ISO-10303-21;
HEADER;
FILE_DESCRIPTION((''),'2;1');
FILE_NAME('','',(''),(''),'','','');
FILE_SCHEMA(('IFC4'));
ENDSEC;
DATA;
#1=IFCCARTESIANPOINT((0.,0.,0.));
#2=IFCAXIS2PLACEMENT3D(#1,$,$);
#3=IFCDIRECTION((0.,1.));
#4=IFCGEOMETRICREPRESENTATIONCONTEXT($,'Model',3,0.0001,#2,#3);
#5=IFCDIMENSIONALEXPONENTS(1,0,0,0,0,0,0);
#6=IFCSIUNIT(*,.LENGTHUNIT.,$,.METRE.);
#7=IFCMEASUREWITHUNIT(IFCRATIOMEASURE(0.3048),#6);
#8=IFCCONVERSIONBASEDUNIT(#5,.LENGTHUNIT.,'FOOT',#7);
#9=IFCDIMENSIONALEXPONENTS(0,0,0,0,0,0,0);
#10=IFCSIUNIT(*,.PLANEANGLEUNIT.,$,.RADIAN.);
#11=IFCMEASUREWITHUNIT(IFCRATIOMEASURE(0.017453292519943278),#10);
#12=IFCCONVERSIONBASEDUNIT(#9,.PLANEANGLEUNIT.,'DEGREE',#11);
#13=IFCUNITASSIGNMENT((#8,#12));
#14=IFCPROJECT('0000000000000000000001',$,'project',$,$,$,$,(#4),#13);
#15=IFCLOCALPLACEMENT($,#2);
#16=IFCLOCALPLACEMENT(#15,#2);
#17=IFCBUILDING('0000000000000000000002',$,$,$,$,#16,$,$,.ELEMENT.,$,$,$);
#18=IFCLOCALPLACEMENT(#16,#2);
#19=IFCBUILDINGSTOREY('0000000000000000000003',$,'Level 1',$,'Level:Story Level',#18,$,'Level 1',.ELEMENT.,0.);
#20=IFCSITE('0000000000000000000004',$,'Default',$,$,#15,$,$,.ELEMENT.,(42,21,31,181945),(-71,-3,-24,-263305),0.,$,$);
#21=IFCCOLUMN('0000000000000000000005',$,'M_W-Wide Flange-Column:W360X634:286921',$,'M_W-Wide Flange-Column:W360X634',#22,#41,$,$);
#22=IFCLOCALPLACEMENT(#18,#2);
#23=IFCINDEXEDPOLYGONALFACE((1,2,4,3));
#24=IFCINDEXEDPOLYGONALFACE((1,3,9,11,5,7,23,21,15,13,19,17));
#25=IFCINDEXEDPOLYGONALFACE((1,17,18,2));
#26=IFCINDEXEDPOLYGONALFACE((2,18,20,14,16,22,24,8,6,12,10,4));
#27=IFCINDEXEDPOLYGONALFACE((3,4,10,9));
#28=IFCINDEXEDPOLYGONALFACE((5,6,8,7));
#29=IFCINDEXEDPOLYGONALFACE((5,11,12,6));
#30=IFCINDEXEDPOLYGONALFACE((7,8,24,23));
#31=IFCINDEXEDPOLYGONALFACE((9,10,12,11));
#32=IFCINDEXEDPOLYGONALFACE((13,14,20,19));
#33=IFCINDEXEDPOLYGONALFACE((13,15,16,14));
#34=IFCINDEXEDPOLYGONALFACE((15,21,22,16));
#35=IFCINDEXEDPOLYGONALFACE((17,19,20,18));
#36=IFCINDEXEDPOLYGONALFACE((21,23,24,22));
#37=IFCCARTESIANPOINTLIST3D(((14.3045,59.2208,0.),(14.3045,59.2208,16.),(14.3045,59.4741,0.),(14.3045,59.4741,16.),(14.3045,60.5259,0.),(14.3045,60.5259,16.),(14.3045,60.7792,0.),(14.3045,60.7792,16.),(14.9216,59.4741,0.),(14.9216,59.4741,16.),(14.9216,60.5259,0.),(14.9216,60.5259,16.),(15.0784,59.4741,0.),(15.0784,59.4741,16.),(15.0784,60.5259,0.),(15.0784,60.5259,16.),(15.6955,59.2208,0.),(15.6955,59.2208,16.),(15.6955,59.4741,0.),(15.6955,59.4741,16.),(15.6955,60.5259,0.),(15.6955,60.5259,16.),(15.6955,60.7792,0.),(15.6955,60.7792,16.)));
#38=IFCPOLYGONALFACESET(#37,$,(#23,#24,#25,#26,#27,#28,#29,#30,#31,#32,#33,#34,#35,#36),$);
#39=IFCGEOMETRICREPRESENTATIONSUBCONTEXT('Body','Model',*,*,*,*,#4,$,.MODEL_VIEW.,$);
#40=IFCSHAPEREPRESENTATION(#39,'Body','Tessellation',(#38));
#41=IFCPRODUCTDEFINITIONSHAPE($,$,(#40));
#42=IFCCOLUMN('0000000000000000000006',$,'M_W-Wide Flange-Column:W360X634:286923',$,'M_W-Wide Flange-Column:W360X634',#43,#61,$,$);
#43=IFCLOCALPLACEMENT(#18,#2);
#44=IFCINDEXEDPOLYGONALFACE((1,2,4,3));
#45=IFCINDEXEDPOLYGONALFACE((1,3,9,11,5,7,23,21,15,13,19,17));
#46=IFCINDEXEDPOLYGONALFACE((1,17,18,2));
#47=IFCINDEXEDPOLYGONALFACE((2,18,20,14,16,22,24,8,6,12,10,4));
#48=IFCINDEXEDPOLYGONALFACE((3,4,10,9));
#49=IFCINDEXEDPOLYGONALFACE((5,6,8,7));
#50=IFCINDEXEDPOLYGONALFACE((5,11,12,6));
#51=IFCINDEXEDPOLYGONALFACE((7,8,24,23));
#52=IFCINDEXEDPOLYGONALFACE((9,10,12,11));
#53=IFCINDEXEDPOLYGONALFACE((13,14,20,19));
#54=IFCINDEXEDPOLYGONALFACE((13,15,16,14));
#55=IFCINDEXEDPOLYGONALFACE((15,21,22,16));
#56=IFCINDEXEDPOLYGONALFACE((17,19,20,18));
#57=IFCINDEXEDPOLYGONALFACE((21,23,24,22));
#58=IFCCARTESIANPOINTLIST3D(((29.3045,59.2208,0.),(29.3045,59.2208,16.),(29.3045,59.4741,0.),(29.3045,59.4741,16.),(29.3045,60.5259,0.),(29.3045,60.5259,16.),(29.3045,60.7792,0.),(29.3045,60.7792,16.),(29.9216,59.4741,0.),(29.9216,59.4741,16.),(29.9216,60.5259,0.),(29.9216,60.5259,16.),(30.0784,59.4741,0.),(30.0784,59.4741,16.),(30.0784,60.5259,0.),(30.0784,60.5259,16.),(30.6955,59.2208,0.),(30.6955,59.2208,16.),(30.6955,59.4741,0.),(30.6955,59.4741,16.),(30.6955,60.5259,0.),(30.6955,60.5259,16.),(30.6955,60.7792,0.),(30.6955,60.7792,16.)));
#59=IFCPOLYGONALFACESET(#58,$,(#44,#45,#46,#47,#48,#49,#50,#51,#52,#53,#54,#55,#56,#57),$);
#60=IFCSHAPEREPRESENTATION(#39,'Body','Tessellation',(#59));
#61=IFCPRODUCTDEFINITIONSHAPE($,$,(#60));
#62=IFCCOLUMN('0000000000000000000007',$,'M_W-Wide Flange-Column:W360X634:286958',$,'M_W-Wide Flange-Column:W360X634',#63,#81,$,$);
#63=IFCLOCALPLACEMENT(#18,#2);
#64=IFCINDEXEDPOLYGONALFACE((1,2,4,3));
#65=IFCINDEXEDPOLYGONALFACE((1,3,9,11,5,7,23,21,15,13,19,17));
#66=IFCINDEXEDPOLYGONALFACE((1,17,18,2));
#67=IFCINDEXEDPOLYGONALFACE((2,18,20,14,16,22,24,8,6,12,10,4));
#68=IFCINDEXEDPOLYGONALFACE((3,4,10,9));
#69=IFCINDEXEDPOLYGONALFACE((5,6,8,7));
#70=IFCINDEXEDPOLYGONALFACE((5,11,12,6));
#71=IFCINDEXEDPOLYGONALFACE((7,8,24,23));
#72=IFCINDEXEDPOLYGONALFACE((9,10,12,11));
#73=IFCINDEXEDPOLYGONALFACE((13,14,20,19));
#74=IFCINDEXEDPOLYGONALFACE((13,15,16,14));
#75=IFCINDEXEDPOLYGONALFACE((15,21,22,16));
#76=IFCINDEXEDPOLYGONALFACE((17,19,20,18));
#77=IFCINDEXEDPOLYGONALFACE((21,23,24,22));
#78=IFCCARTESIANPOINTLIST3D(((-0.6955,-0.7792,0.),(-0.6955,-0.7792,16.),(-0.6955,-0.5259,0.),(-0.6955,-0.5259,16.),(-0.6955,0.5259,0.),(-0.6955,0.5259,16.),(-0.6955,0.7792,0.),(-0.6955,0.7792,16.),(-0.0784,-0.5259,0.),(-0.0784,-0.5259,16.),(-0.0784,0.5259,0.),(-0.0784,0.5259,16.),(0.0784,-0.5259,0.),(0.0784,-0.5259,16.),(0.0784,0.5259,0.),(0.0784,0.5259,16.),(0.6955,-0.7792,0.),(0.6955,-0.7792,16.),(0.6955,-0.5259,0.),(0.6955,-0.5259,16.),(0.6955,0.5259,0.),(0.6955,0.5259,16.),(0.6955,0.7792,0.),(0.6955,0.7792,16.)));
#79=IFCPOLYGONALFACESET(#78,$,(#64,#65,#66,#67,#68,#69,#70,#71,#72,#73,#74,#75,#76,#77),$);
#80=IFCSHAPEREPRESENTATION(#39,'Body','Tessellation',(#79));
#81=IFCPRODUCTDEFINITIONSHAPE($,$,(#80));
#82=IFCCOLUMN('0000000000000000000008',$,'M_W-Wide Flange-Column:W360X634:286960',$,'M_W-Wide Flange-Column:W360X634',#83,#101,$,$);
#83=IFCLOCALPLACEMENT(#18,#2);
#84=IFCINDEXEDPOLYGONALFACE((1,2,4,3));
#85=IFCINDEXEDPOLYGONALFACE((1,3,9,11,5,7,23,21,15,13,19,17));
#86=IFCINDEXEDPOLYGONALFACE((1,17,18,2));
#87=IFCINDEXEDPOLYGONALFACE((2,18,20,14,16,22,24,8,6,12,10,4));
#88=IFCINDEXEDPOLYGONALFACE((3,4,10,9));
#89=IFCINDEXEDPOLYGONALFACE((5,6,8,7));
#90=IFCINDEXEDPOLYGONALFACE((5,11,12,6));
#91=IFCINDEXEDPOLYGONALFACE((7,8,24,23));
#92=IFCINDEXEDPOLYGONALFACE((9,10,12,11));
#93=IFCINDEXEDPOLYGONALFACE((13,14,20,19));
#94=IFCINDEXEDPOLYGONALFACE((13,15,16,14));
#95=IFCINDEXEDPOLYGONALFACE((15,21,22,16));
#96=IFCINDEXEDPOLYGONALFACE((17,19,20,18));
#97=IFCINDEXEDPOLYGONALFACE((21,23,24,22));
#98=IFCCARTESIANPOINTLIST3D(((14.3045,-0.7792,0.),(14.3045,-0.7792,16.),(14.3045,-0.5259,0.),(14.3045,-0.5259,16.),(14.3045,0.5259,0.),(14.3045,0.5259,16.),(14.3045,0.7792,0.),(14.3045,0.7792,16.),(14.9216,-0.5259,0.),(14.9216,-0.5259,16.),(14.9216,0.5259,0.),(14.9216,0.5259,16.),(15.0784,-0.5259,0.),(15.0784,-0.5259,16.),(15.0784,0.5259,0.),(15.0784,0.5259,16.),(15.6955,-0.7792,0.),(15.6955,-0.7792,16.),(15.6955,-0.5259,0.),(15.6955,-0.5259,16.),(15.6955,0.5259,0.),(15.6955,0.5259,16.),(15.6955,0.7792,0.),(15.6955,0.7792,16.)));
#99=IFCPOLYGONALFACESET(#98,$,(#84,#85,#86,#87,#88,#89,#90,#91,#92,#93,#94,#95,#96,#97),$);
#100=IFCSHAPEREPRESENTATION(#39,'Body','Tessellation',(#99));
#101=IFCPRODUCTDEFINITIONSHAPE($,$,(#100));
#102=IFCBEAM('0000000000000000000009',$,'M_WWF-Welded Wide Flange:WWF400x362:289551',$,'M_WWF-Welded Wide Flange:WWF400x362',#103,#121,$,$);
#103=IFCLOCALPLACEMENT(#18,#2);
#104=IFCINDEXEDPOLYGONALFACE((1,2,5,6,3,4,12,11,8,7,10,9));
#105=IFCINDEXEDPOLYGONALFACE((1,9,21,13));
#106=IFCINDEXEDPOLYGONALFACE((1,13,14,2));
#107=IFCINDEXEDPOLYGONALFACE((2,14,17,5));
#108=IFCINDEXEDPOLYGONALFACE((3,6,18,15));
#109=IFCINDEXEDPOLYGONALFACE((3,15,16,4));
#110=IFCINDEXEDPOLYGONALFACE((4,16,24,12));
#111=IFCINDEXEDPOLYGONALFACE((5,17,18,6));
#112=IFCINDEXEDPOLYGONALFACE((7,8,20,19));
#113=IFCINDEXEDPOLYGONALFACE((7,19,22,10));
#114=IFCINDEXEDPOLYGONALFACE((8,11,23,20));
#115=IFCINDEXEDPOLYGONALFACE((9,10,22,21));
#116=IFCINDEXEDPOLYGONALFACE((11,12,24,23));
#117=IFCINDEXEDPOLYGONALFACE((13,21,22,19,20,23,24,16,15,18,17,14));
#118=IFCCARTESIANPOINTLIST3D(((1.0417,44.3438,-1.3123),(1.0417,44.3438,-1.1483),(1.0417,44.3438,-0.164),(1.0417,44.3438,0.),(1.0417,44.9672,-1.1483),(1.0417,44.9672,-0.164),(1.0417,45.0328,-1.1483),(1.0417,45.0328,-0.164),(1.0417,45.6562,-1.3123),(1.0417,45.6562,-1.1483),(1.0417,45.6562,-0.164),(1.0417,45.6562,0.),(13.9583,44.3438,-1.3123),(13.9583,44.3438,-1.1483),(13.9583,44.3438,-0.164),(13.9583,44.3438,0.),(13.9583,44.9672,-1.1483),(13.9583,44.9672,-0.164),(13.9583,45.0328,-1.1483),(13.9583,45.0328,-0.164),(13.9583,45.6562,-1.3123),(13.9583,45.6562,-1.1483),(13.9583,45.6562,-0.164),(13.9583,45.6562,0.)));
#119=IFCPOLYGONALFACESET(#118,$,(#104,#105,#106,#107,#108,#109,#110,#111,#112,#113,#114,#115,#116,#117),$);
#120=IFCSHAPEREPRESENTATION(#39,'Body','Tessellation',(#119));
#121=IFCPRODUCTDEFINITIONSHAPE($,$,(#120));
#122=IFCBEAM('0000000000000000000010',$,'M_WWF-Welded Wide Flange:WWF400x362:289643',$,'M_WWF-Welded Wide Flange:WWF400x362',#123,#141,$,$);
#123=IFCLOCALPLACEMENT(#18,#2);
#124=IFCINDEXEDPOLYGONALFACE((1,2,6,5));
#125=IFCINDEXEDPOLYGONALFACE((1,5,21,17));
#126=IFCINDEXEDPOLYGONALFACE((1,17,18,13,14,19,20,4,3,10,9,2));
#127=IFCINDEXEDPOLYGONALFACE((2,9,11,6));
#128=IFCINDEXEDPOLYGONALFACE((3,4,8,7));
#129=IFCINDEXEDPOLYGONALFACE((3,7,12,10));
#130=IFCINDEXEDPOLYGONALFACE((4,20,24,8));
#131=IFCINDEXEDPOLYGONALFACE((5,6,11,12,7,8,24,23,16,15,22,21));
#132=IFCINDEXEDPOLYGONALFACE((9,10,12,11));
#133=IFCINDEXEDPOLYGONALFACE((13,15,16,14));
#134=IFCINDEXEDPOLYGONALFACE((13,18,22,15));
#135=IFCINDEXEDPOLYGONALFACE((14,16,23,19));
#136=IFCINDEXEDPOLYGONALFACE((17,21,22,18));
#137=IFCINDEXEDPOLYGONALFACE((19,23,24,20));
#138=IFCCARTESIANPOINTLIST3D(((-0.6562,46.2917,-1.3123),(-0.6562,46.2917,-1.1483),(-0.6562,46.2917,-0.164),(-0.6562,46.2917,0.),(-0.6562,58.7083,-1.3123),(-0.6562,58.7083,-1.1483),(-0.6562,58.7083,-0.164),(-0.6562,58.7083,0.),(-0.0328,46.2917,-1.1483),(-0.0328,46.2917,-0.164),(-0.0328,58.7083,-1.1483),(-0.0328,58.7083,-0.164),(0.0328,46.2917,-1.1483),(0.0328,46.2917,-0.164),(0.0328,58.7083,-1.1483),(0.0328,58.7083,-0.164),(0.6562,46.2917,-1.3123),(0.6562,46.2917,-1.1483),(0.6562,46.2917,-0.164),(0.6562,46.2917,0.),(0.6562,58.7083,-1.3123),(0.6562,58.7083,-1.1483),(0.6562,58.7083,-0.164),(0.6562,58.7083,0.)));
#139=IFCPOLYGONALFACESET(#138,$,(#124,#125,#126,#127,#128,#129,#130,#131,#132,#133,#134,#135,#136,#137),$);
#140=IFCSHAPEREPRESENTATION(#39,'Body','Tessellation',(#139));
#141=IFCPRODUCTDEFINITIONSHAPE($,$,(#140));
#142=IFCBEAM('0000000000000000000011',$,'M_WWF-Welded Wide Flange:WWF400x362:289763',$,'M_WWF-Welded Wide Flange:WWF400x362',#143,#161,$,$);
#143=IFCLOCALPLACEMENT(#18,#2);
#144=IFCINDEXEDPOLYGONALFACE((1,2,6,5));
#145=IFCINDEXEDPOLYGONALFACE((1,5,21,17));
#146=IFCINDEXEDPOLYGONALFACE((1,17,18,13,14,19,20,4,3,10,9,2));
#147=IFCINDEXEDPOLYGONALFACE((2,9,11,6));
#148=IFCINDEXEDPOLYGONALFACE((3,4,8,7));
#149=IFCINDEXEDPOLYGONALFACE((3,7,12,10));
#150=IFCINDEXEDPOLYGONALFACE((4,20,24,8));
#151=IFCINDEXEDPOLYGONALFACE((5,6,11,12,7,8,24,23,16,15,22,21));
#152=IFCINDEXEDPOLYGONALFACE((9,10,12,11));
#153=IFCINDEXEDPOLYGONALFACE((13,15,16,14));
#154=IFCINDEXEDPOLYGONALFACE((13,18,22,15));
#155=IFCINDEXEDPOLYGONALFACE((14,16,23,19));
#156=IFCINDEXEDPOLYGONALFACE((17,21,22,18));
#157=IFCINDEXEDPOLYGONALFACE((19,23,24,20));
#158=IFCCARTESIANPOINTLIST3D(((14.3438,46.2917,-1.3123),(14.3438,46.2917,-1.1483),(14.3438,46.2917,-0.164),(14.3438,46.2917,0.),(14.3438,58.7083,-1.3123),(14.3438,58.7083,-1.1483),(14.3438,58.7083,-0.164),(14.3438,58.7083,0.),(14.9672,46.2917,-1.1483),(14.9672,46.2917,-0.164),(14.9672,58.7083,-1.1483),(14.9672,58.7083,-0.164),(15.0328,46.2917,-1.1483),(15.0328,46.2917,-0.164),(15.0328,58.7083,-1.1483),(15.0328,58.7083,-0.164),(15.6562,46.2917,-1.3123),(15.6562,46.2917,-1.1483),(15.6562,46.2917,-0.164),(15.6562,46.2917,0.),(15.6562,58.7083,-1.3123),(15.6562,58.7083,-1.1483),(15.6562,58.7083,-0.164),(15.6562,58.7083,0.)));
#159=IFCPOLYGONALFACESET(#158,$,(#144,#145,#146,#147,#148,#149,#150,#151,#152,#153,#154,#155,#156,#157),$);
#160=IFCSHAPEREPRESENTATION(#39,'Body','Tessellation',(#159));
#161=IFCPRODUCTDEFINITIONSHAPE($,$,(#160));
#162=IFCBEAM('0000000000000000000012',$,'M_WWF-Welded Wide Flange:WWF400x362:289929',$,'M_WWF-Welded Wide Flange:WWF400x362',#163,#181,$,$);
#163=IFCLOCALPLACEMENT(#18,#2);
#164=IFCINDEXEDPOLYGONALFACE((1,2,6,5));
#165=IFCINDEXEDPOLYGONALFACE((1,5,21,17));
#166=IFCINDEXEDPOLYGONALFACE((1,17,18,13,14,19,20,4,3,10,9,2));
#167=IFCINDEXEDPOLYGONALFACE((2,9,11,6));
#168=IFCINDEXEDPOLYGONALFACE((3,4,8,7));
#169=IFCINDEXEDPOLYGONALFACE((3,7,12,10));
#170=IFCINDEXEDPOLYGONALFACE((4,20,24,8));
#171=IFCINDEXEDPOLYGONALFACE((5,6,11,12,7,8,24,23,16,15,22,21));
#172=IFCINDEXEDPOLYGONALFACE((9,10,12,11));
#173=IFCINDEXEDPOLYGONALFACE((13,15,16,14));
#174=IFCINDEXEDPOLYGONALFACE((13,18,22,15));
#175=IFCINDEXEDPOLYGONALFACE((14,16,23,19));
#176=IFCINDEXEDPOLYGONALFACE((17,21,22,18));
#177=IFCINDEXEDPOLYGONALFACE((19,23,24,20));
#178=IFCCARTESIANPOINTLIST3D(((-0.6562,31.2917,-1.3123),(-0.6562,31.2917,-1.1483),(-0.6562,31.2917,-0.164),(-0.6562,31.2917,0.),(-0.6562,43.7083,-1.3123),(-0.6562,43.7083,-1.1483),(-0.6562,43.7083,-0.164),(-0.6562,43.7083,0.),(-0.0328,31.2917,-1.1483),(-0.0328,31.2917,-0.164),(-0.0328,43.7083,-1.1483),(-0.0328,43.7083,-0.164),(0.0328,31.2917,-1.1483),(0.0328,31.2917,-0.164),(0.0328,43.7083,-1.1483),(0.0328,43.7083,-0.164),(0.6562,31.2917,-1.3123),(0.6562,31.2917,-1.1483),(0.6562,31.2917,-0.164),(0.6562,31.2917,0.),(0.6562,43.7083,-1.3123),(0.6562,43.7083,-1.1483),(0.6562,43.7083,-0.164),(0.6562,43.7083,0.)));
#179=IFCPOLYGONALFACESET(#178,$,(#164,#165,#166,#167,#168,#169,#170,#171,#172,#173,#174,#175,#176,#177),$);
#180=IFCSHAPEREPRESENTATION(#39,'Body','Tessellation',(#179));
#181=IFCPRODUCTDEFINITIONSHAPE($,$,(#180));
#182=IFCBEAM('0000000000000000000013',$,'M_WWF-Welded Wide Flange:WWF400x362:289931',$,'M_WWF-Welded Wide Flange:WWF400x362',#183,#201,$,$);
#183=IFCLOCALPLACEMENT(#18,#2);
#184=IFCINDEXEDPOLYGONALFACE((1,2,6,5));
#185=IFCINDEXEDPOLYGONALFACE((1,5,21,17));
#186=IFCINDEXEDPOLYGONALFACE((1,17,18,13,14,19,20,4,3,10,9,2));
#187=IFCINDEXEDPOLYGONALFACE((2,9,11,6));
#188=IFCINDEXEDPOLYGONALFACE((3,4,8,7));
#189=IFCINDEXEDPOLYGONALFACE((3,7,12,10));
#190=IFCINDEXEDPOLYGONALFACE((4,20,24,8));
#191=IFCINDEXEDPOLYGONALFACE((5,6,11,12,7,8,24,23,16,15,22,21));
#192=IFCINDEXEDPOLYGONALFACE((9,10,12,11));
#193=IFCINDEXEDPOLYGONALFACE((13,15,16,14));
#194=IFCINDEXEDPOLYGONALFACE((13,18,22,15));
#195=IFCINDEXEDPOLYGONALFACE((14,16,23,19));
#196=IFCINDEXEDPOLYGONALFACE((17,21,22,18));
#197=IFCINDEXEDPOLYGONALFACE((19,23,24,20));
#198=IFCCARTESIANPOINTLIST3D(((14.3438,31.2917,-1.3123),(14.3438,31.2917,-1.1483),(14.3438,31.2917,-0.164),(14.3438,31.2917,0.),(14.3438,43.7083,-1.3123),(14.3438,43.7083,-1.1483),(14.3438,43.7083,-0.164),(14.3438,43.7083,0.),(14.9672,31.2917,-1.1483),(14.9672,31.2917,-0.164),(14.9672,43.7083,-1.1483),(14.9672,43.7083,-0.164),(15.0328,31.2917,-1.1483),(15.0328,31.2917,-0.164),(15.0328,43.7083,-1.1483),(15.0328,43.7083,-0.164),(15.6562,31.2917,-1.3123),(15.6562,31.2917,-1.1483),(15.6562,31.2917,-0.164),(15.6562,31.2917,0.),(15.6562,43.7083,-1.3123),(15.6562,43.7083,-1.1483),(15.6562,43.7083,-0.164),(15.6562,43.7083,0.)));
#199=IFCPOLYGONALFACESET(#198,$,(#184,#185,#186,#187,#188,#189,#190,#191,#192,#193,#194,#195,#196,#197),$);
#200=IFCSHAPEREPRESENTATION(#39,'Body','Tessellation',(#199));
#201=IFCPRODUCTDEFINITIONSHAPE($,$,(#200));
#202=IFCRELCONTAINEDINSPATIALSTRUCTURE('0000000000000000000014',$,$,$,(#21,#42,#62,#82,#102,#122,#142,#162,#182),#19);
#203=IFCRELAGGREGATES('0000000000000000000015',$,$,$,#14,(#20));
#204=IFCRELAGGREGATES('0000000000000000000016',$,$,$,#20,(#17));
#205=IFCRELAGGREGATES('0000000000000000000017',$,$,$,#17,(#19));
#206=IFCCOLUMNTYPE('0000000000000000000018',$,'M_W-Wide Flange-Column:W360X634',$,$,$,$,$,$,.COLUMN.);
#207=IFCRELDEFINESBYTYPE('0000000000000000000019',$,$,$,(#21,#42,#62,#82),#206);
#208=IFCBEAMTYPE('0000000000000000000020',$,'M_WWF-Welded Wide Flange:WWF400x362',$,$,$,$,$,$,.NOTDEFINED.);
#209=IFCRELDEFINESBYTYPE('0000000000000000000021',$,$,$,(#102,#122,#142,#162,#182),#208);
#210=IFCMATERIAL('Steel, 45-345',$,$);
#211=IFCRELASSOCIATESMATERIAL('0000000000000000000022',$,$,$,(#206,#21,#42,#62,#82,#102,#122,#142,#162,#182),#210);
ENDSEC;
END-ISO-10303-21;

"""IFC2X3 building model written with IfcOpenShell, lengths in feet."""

from ifc_helpers import new_model, entity, si_unit, converted_unit, direction, frame, frame_2d, origin, place, context, subcontext, project, spatial, polyline, i_section, outline, extrude, source, transform, mapped, material, type_object, type_shapes, element, save


model = new_model("IFC2X3")

# Units and contexts
model_context = context("Model", 3, precision=0.0001, world=origin(), true_north=direction((0.0, 1.0)))
body_context = subcontext(model_context, "Body", "Model", "MODEL_VIEW")
ifc_project = project(units=[converted_unit("LENGTHUNIT", "FOOT", entity("IfcRatioMeasure", 0.3048), si_unit("LENGTHUNIT", "METRE"), dimensions=[1, 0, 0, 0, 0, 0, 0]), converted_unit("PLANEANGLEUNIT", "DEGREE", entity("IfcRatioMeasure", 0.017453292519943278), si_unit("PLANEANGLEUNIT", "RADIAN"), dimensions=[0, 0, 0, 0, 0, 0, 0])], contexts=[model_context])

# Site, building, storey
site_placement = place(None, origin())
site = spatial("IfcSite", under=ifc_project, at=site_placement, Name="Default", CompositionType="ELEMENT", RefLatitude=(42, 21, 31, 181945), RefLongitude=(-71, -3, -24, -263305), RefElevation=0.0)
building_placement = place(site_placement, origin())
building = spatial("IfcBuilding", under=site, at=building_placement, CompositionType="ELEMENT")
storey_placement = place(building_placement, origin())
storey = spatial("IfcBuildingStorey", under=building, at=storey_placement, Name="Level 1", ObjectType="Level:Story Level", LongName="Level 1", CompositionType="ELEMENT", Elevation=0.0)

# Columns
ifc_material = material(Name="Steel, 45-345")
column_type = type_object("IfcColumnType", Name="M_W-Wide Flange-Column:W360X634", PredefinedType="COLUMN", material=ifc_material)
shared_shape = source(origin(), body_context, "Body", "SweptSolid", [
    extrude(outline(polyline([(0.5259, -0.6955), (0.7792, -0.6955), (0.7792, 0.6955), (0.5259, 0.6955), (0.5259, 0.0784), (-0.5259, 0.0784), (-0.5259, 0.6955), (-0.7792, 0.6955), (-0.7792, -0.6955), (-0.5259, -0.6955), (-0.5259, -0.0784), (0.5259, -0.0784), (0.5259, -0.6955)])), frame((0.0, 0.0, 0.0), z_axis=(0.0, 0.0, 1.0), x_axis=(0.0, -1.0, 0.0)), (0.0, 0.0, 1.0), 16.0),
])
type_shapes(column_type, [shared_shape])
for number, where, name in (
    (1, (15.0, 60.0, 0.0), "M_W-Wide Flange-Column:W360X634:286921"),
    (2, (30.0, 60.0, 0.0), "M_W-Wide Flange-Column:W360X634:286923"),
    (3, (0.0, 0.0, 0.0), "M_W-Wide Flange-Column:W360X634:286958"),
    (4, (15.0, 0.0, 0.0), "M_W-Wide Flange-Column:W360X634:286960"),
):
    element("IfcColumn", number, at=place(storey_placement, frame(where)), inside=storey, type_object=column_type, material=ifc_material, Name=name, ObjectType="M_W-Wide Flange-Column:W360X634", context=body_context, shape_type="MappedRepresentation", body=[
        mapped(shared_shape, transform((0.0, 0.0, 0.0), scale=1.0)),
    ])

# Beams
beam_type = type_object("IfcBeamType", Name="M_WWF-Welded Wide Flange:WWF400x362", PredefinedType="NOTDEFINED")
beam_1_placement = place(storey_placement, frame((0.0, 45.0, 0.0)))
element("IfcBeam", 5, at=beam_1_placement, inside=storey, type_object=beam_type, material=ifc_material, Name="M_WWF-Welded Wide Flange:WWF400x362:289551", ObjectType="M_WWF-Welded Wide Flange:WWF400x362", context=body_context, shape_type="SweptSolid", body=[
    extrude(i_section(OverallWidth=1.3123, OverallDepth=1.3123, WebThickness=0.0656, FlangeThickness=0.164, at=frame_2d((0.0, 0.0), x_axis=(0.0, 1.0))), frame((1.0417, 0.0, -0.6562), z_axis=(1.0, 0.0, 0.0), x_axis=(0.0, 0.0, -1.0)), (0.0, 0.0, 1.0), 12.9167),
])
beam_2_placement = place(storey_placement, frame((0.0, 45.0, 0.0), z_axis=(0.0, 0.0, 1.0), x_axis=(0.0, 1.0, 0.0)))
element("IfcBeam", 6, at=beam_2_placement, inside=storey, type_object=beam_type, material=ifc_material, Name="M_WWF-Welded Wide Flange:WWF400x362:289643", ObjectType="M_WWF-Welded Wide Flange:WWF400x362", context=body_context, shape_type="SweptSolid", body=[
    extrude(i_section(OverallWidth=1.3123, OverallDepth=1.3123, WebThickness=0.0656, FlangeThickness=0.164, at=frame_2d((0.0, 0.0), x_axis=(0.0, 1.0))), frame((1.2917, 0.0, -0.6562), z_axis=(1.0, 0.0, 0.0), x_axis=(0.0, 0.0, -1.0)), (0.0, 0.0, 1.0), 12.4167),
])
beam_3_placement = place(storey_placement, frame((15.0, 45.0, 0.0), z_axis=(0.0, 0.0, 1.0), x_axis=(0.0, 1.0, 0.0)))
element("IfcBeam", 7, at=beam_3_placement, inside=storey, type_object=beam_type, material=ifc_material, Name="M_WWF-Welded Wide Flange:WWF400x362:289763", ObjectType="M_WWF-Welded Wide Flange:WWF400x362", context=body_context, shape_type="SweptSolid", body=[
    extrude(i_section(OverallWidth=1.3123, OverallDepth=1.3123, WebThickness=0.0656, FlangeThickness=0.164, at=frame_2d((0.0, 0.0), x_axis=(0.0, 1.0))), frame((1.2917, 0.0, -0.6562), z_axis=(1.0, 0.0, 0.0), x_axis=(0.0, 0.0, -1.0)), (0.0, 0.0, 1.0), 12.4167),
])
beam_4_placement = place(storey_placement, frame((0.0, 30.0, 0.0), z_axis=(0.0, 0.0, 1.0), x_axis=(0.0, 1.0, 0.0)))
element("IfcBeam", 8, at=beam_4_placement, inside=storey, type_object=beam_type, material=ifc_material, Name="M_WWF-Welded Wide Flange:WWF400x362:289929", ObjectType="M_WWF-Welded Wide Flange:WWF400x362", context=body_context, shape_type="SweptSolid", body=[
    extrude(i_section(OverallWidth=1.3123, OverallDepth=1.3123, WebThickness=0.0656, FlangeThickness=0.164, at=frame_2d((0.0, 0.0), x_axis=(0.0, 1.0))), frame((1.2917, 0.0, -0.6562), z_axis=(1.0, 0.0, 0.0), x_axis=(0.0, 0.0, -1.0)), (0.0, 0.0, 1.0), 12.4167),
])
beam_5_placement = place(storey_placement, frame((15.0, 30.0, 0.0), z_axis=(0.0, 0.0, 1.0), x_axis=(0.0, 1.0, 0.0)))
element("IfcBeam", 9, at=beam_5_placement, inside=storey, type_object=beam_type, material=ifc_material, Name="M_WWF-Welded Wide Flange:WWF400x362:289931", ObjectType="M_WWF-Welded Wide Flange:WWF400x362", context=body_context, shape_type="SweptSolid", body=[
    extrude(i_section(OverallWidth=1.3123, OverallDepth=1.3123, WebThickness=0.0656, FlangeThickness=0.164, at=frame_2d((0.0, 0.0), x_axis=(0.0, 1.0))), frame((1.2917, 0.0, -0.6562), z_axis=(1.0, 0.0, 0.0), x_axis=(0.0, 0.0, -1.0)), (0.0, 0.0, 1.0), 12.4167),
])

save(model, "model.ifc")
